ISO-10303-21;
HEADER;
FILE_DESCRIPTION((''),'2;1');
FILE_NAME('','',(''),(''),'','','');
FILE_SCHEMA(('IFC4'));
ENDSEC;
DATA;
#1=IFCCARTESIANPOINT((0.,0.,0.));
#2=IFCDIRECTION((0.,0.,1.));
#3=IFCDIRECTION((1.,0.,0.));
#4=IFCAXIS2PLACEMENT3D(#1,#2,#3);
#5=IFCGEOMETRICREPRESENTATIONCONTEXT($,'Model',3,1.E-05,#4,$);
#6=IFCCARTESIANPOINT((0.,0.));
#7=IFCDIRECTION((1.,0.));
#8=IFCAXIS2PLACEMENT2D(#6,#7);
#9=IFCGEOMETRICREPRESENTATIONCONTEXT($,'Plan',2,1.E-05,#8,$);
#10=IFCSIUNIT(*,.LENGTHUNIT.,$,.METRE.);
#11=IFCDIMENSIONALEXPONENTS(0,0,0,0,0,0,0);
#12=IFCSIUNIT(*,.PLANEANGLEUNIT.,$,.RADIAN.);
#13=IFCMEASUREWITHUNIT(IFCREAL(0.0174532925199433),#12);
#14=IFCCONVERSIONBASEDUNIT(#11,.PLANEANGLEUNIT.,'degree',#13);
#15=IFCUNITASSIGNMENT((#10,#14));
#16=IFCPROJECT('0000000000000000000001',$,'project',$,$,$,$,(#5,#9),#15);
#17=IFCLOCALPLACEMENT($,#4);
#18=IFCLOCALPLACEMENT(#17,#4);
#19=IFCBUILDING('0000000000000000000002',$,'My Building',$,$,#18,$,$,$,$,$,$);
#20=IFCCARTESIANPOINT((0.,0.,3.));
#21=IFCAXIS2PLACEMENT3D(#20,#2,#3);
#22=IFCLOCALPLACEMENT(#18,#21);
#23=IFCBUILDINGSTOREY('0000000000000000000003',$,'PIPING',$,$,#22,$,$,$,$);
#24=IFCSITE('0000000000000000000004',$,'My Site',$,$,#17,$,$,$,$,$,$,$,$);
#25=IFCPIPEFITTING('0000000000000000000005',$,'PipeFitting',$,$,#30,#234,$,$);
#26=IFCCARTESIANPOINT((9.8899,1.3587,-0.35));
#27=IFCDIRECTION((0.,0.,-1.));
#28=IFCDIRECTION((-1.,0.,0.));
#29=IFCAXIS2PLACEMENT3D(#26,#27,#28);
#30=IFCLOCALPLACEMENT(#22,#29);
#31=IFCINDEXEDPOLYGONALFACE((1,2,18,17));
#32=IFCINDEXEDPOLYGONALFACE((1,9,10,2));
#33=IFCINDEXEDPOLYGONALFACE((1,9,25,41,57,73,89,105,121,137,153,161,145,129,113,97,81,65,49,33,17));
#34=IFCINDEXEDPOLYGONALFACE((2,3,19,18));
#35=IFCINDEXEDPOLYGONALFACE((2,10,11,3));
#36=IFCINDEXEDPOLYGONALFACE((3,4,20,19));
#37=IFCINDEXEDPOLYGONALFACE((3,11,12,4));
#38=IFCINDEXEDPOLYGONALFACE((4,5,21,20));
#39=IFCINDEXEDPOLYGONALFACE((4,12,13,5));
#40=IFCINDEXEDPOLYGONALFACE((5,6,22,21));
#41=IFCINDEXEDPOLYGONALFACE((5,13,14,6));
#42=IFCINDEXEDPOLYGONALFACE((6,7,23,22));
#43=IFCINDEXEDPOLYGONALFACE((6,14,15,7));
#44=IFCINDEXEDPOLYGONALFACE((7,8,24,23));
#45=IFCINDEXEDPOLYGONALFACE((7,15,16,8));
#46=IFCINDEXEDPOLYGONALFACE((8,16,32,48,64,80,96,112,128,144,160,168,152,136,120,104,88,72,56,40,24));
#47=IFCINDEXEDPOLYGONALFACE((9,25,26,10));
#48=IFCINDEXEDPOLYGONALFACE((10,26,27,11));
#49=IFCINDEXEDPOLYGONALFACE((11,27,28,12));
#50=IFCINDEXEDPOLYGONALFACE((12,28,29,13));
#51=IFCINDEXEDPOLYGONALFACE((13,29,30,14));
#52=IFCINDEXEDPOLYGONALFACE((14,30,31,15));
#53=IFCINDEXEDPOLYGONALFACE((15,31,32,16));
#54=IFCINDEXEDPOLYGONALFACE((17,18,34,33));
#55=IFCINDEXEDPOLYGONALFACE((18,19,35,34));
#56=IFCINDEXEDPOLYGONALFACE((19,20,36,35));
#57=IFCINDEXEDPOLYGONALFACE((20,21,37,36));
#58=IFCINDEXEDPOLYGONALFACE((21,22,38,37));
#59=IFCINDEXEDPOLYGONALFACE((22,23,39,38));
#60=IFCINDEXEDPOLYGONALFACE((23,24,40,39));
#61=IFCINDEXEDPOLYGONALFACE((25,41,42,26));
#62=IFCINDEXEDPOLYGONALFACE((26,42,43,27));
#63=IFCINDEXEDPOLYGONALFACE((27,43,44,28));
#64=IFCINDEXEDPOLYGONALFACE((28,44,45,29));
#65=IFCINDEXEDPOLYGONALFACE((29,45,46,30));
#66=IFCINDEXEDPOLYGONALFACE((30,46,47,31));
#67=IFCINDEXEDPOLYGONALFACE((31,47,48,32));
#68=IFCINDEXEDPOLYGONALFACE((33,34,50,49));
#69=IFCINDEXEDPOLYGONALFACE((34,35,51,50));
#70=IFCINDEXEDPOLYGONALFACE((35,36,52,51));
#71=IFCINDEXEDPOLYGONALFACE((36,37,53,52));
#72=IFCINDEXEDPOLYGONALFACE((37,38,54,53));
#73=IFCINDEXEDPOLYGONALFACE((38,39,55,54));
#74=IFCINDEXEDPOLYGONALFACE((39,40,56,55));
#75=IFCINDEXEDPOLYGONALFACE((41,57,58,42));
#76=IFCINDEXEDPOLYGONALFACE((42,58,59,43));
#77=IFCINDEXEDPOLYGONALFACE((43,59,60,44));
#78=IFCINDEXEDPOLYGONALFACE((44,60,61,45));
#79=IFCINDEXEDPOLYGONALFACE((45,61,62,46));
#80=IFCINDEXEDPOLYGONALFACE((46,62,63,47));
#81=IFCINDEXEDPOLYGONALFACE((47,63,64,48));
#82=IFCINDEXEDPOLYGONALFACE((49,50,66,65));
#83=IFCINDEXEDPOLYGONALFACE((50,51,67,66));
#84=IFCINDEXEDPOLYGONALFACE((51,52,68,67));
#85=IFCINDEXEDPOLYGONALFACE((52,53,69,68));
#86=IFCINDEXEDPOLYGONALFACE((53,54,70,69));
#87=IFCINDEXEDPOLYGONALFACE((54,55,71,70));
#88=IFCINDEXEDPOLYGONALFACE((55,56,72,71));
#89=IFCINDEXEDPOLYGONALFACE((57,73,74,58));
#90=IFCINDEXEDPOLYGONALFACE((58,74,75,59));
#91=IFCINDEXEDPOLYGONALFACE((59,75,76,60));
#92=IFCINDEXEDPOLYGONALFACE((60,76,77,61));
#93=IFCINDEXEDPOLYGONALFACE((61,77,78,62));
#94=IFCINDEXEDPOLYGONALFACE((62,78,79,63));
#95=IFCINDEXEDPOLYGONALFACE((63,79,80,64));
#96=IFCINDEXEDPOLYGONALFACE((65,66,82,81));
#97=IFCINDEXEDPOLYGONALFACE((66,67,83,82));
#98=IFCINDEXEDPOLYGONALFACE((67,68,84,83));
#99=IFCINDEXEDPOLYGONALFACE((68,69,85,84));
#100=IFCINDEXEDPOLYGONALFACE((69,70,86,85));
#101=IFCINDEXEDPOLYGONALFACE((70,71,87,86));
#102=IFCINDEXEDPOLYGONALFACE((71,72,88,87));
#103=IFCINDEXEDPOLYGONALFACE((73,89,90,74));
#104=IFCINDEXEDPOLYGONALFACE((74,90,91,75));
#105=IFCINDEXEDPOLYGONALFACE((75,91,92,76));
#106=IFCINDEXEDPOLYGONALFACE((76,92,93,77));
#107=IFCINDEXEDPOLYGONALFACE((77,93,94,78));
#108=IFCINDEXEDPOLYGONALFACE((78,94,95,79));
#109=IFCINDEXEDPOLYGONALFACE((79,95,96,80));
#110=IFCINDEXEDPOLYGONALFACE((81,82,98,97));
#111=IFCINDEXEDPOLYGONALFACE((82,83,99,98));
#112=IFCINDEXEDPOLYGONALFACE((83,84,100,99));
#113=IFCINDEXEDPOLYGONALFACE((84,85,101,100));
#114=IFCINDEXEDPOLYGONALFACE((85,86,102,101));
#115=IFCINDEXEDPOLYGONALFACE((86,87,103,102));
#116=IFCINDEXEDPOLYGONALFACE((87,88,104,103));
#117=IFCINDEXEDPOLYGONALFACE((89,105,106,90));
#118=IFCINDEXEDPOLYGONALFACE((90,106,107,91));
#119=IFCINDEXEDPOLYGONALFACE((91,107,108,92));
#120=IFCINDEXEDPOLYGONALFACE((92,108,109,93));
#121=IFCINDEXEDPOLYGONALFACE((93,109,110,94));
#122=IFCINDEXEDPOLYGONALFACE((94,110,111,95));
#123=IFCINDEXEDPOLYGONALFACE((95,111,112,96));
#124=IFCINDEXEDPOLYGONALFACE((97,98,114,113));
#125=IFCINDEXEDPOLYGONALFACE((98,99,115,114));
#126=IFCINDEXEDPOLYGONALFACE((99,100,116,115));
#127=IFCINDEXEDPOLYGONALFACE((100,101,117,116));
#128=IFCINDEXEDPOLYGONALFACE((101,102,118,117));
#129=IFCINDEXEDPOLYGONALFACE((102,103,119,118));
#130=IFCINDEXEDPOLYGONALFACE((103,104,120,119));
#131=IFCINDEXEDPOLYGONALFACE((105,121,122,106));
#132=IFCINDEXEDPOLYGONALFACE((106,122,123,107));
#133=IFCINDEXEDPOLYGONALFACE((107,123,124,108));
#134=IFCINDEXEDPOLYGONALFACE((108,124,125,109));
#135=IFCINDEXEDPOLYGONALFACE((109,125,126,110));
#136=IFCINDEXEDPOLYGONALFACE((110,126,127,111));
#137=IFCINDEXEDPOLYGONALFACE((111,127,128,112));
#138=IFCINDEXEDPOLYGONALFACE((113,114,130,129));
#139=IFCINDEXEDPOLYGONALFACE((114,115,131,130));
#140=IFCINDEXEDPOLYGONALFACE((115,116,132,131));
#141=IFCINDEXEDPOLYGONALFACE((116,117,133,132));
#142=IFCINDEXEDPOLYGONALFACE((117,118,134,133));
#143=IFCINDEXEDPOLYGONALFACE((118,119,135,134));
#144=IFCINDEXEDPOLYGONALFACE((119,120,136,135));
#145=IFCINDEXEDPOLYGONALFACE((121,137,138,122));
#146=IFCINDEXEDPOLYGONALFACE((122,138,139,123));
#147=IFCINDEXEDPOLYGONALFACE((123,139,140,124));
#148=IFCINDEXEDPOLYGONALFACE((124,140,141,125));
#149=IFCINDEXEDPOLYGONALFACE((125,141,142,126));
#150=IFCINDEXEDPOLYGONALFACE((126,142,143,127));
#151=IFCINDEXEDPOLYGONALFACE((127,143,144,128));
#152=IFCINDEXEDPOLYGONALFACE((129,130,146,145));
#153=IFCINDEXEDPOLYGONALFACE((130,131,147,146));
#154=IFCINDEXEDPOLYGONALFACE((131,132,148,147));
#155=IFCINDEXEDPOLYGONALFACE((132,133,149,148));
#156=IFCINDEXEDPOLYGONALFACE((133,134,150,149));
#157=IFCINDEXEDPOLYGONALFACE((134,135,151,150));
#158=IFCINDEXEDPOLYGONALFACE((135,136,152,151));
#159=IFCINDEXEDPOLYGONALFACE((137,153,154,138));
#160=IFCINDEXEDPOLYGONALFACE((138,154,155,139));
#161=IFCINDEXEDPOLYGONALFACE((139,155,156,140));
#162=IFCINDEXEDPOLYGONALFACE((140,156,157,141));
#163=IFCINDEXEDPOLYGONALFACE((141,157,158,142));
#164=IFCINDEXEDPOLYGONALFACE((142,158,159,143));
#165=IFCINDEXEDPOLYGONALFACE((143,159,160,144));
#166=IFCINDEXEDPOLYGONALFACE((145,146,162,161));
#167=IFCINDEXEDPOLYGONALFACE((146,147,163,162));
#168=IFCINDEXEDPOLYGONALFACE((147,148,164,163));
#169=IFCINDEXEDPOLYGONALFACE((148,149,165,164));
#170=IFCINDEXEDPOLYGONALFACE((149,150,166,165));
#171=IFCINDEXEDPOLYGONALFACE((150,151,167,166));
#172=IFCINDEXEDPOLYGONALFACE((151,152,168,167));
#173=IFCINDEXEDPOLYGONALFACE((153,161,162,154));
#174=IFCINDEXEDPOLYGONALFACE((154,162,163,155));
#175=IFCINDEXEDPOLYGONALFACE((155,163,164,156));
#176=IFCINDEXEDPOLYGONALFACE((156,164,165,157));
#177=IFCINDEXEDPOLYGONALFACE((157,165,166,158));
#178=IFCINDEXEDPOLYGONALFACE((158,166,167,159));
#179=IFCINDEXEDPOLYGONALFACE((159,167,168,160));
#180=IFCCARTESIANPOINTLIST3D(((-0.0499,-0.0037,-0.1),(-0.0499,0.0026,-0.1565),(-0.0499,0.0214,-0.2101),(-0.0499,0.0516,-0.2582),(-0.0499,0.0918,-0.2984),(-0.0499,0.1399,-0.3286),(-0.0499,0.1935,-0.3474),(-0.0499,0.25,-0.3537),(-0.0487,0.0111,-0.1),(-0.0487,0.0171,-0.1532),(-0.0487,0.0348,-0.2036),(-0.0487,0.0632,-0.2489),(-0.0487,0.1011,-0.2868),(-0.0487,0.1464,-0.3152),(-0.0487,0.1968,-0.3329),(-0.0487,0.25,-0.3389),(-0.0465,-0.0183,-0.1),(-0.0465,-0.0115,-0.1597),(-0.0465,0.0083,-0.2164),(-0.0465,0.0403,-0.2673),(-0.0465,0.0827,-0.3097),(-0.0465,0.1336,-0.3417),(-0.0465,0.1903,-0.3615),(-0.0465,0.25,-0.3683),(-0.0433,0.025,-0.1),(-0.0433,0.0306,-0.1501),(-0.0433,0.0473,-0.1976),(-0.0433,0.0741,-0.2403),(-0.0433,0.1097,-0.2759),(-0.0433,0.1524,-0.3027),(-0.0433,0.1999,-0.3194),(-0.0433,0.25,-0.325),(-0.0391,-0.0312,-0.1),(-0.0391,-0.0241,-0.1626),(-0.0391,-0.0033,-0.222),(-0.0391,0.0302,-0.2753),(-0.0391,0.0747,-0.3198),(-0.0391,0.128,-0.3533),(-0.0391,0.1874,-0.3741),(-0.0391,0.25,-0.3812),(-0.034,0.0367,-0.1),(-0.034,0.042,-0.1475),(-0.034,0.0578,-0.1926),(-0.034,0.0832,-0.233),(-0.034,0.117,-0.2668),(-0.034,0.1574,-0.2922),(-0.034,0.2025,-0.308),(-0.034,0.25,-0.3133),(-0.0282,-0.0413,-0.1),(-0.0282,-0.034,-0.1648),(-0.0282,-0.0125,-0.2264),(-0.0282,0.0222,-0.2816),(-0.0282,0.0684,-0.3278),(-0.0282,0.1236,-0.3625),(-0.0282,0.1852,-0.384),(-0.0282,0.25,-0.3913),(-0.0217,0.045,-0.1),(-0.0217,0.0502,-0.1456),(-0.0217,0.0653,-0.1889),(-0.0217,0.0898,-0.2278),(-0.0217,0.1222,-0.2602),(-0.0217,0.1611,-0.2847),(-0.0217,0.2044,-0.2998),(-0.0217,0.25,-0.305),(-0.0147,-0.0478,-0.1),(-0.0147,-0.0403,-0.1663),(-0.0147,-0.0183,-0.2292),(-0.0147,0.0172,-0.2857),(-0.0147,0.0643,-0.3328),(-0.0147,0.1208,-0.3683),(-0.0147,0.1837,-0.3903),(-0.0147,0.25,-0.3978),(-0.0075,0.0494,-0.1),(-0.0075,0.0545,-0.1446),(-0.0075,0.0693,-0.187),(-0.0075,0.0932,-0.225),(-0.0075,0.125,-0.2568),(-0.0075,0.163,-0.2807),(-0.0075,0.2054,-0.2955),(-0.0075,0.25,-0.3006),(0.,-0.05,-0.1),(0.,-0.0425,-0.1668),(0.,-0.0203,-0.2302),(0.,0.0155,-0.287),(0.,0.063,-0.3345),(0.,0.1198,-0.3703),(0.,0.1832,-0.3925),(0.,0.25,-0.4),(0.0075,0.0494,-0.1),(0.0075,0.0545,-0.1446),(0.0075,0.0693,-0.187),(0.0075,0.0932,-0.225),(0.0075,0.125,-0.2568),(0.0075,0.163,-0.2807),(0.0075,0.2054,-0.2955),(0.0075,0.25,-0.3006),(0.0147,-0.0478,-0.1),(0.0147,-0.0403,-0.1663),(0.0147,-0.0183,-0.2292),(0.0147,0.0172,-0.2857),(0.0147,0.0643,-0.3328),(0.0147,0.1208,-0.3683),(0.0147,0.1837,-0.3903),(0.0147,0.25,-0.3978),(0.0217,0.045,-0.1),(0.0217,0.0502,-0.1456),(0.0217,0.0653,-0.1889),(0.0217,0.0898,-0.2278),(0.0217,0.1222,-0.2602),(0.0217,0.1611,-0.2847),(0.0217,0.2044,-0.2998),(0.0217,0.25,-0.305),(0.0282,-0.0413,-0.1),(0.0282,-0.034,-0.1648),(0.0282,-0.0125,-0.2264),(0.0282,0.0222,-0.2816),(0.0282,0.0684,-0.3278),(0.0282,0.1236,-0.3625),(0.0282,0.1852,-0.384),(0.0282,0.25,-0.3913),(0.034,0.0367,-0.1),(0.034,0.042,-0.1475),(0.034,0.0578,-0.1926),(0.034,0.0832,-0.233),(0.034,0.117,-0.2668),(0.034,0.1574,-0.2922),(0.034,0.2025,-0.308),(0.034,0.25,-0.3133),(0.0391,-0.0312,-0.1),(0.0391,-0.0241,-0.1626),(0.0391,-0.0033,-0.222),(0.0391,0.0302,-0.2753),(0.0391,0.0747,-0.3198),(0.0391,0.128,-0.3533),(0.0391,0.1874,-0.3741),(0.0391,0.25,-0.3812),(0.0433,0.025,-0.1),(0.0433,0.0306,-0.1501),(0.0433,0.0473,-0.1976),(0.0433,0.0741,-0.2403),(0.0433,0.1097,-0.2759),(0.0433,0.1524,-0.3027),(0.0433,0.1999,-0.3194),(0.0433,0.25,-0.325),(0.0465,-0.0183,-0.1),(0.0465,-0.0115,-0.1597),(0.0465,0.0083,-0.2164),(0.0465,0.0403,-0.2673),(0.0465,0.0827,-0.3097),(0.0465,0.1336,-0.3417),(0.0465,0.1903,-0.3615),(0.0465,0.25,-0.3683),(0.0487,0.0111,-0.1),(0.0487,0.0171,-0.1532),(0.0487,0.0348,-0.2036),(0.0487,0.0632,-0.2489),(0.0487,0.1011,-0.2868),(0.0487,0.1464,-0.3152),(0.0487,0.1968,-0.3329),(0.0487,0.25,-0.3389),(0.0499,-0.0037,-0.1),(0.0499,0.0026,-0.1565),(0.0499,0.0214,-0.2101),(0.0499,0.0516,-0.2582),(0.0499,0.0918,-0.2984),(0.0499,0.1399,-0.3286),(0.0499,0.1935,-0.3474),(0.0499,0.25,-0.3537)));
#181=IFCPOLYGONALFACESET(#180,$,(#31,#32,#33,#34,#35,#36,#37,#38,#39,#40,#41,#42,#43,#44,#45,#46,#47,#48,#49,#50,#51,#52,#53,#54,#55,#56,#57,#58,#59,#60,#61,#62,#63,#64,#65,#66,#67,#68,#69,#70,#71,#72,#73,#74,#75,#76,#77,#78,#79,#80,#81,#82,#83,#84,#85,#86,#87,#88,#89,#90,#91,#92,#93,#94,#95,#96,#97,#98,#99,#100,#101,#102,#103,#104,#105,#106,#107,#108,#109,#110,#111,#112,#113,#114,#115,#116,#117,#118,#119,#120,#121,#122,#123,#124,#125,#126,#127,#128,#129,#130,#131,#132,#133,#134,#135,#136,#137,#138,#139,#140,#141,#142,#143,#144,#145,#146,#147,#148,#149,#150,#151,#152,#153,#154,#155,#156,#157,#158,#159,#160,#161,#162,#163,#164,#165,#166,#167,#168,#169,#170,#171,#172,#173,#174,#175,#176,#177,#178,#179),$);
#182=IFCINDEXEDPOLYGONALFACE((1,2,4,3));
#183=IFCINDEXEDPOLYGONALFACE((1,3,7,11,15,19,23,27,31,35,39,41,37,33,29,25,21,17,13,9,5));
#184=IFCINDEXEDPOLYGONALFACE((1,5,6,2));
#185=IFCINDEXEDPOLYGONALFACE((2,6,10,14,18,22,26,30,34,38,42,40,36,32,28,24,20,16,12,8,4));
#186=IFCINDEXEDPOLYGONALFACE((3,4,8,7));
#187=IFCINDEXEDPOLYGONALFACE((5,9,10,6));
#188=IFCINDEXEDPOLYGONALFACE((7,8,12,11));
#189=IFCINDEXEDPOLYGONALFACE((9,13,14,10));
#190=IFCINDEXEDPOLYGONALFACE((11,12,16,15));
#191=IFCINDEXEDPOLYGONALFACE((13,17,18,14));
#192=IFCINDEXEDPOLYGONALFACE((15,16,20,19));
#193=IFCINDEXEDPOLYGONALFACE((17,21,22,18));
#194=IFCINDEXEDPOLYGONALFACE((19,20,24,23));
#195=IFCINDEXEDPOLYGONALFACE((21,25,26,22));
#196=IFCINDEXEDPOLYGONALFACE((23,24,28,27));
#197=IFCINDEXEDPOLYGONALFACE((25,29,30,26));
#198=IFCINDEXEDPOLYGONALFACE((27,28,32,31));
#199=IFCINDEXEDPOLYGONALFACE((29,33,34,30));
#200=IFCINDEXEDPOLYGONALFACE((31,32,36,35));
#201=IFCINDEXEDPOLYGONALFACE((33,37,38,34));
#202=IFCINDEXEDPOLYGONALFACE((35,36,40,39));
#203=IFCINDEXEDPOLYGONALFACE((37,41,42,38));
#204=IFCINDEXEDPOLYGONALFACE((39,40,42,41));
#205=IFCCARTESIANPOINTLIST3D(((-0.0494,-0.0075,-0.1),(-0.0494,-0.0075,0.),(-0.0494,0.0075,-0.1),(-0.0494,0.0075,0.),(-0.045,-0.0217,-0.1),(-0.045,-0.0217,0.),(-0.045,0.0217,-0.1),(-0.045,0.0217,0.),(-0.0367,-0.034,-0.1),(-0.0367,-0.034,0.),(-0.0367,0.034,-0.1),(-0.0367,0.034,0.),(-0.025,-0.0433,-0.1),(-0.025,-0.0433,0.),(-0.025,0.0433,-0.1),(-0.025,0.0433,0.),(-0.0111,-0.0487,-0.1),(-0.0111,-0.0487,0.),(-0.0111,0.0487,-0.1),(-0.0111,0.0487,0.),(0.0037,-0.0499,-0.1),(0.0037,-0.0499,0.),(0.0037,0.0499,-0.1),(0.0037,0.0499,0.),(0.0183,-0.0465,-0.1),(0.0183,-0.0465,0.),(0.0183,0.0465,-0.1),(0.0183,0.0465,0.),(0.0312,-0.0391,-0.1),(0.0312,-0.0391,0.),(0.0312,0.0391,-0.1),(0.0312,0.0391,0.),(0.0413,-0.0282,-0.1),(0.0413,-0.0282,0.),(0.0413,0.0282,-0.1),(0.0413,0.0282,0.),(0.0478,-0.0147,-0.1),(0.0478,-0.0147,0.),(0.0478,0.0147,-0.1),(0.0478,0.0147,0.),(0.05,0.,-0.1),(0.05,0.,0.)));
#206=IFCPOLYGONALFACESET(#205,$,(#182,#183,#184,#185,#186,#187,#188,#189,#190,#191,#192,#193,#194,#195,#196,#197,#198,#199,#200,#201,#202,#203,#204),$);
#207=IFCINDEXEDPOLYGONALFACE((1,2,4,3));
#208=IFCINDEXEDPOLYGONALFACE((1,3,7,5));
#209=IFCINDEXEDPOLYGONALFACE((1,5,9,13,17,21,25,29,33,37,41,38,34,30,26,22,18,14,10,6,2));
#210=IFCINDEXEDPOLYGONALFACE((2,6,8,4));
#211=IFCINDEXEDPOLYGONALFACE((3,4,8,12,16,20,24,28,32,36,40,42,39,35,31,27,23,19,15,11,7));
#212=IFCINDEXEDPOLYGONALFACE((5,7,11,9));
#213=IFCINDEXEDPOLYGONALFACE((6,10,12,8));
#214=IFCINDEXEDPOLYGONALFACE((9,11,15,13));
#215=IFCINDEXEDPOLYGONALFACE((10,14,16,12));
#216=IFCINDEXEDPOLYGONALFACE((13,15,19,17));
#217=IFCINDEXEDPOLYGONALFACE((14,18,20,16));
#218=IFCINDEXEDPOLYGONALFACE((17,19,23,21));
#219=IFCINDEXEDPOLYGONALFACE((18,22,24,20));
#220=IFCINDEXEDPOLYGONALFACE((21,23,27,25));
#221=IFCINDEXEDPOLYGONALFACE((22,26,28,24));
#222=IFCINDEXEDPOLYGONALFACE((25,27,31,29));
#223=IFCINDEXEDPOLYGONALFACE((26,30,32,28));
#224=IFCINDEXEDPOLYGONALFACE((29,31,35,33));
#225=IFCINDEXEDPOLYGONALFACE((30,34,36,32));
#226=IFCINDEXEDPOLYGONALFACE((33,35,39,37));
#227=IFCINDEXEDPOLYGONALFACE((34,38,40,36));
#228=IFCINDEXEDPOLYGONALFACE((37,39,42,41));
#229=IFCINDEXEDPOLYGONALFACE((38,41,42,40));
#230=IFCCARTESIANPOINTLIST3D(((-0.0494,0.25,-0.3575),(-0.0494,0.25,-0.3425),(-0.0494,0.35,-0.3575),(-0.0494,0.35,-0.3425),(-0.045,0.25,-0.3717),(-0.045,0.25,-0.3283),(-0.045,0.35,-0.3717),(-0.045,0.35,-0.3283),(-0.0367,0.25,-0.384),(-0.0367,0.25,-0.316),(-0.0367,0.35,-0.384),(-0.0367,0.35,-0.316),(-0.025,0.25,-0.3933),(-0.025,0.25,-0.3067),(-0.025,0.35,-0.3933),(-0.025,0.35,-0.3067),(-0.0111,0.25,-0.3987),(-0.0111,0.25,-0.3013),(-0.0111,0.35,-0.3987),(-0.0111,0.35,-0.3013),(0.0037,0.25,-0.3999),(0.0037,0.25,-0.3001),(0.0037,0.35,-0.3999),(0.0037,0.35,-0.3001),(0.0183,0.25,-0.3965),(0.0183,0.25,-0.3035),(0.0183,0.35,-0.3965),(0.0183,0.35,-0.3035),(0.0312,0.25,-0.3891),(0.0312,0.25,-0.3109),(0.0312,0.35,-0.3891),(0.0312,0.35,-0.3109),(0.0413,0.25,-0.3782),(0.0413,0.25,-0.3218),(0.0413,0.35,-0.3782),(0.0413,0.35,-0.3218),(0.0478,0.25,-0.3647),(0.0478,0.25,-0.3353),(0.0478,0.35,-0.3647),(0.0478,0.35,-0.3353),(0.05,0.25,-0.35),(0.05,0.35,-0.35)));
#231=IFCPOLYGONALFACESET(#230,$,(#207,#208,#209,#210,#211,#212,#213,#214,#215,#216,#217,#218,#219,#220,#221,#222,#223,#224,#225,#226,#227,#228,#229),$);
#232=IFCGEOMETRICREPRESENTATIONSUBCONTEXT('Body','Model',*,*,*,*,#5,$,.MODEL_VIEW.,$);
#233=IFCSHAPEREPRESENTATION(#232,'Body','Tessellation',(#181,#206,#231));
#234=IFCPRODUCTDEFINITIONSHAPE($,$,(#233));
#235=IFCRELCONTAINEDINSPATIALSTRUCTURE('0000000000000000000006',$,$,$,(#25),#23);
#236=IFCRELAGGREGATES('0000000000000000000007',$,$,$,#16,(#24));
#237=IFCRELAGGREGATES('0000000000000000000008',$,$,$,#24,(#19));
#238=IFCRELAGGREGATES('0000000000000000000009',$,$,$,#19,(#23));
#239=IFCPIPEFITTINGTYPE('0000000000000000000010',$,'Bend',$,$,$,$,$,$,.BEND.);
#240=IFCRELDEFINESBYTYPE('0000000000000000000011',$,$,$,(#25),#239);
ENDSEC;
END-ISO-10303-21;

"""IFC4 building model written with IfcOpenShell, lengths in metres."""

from ifc_helpers import new_model, entity, si_unit, converted_unit, frame, origin_with_axes, origin_2d_with_axis, place, context, subcontext, project, spatial, line, indexed_curve, circle, outline, extrude, source, transform, mapped, type_object, type_shapes, element, save


model = new_model("IFC4")

# Units and contexts
model_context = context("Model", 3, precision=1e-05, world=origin_with_axes())
plan_context = context("Plan", 2, precision=1e-05, world=origin_2d_with_axis())
body_context = subcontext(model_context, "Body", "Model", "MODEL_VIEW")
ifc_project = project(units=[si_unit("LENGTHUNIT", "METRE"), converted_unit("PLANEANGLEUNIT", "degree", entity("IfcReal", 0.0174532925199433), si_unit("PLANEANGLEUNIT", "RADIAN"), dimensions=[0, 0, 0, 0, 0, 0, 0])], contexts=[model_context, plan_context])

# Site, building, storey
site_placement = place(None, origin_with_axes())
site = spatial("IfcSite", under=ifc_project, at=site_placement, Name="My Site")
building_placement = place(site_placement, origin_with_axes())
building = spatial("IfcBuilding", under=site, at=building_placement, Name="My Building")
storey_placement = place(building_placement, frame((0.0, 0.0, 3.0), z_axis=(0.0, 0.0, 1.0), x_axis=(1.0, 0.0, 0.0)))
storey = spatial("IfcBuildingStorey", under=building, at=storey_placement, Name="PIPING")

# Shared definitions
pipe_fitting_type = type_object("IfcPipeFittingType", Name="Bend", PredefinedType="BEND")
shared_shape = source(origin_with_axes(), body_context, "Body", "SolidModel", [
    entity("IfcSweptDiskSolid", entity("IfcIndexedPolyCurve", entity("IfcCartesianPointList3D", [[0.0, 0.0, -0.1], [0.0, 0.0732, -0.2768], [0.0, 0.25, -0.35]]), [entity("IfcArcIndex", [1, 2, 3])]), 0.05),
    extrude(circle(Radius=0.05), origin_with_axes(), (0.0, 0.0, -1.0), 0.1),
    extrude(circle(Radius=0.05), frame((0.0, 0.25, -0.35), z_axis=(0.0, 1.0, 0.0), x_axis=(1.0, 0.0, 0.0)), (0.0, 0.0, 1.0), 0.1),
])
type_shapes(pipe_fitting_type, [shared_shape])

# Pipe fitting, opening
pipe_fitting_1_placement = place(storey_placement, frame((9.8899, 1.3587, -0.35), z_axis=(0.0, 0.0, -1.0), x_axis=(-1.0, 0.0, 0.0)))
pipe_fitting_1 = element("IfcPipeFitting", 1, at=pipe_fitting_1_placement, inside=storey, type_object=pipe_fitting_type, Name="PipeFitting", context=body_context, shape_type="MappedRepresentation", body=[
    mapped(shared_shape, transform((0.0, 0.0, 0.0), x_axis=(1.0, 0.0, 0.0), y_axis=(0.0, 1.0, 0.0), z_axis=(0.0, 0.0, 1.0), scale=1.0)),
])
opening_1_placement = place(pipe_fitting_1_placement, frame((1.768, -1.3587, 2.65), z_axis=(0.0, 0.0, -1.0), x_axis=(-1.0, 0.0, 0.0)))
element("IfcOpeningElement", 2, at=opening_1_placement, cuts=pipe_fitting_1, PredefinedType="OPENING", context=body_context, shape_type="SweptSolid", body=[
    extrude(outline(indexed_curve([(0.0, 0.0), (0.5, 0.0), (0.5, 0.5), (0.0, 0.5)], segments=[line(1, 2, 3, 4, 1)])), origin_with_axes(), (0.0, 0.0, 1.0), 0.5),
])

save(model, "model.ifc")
